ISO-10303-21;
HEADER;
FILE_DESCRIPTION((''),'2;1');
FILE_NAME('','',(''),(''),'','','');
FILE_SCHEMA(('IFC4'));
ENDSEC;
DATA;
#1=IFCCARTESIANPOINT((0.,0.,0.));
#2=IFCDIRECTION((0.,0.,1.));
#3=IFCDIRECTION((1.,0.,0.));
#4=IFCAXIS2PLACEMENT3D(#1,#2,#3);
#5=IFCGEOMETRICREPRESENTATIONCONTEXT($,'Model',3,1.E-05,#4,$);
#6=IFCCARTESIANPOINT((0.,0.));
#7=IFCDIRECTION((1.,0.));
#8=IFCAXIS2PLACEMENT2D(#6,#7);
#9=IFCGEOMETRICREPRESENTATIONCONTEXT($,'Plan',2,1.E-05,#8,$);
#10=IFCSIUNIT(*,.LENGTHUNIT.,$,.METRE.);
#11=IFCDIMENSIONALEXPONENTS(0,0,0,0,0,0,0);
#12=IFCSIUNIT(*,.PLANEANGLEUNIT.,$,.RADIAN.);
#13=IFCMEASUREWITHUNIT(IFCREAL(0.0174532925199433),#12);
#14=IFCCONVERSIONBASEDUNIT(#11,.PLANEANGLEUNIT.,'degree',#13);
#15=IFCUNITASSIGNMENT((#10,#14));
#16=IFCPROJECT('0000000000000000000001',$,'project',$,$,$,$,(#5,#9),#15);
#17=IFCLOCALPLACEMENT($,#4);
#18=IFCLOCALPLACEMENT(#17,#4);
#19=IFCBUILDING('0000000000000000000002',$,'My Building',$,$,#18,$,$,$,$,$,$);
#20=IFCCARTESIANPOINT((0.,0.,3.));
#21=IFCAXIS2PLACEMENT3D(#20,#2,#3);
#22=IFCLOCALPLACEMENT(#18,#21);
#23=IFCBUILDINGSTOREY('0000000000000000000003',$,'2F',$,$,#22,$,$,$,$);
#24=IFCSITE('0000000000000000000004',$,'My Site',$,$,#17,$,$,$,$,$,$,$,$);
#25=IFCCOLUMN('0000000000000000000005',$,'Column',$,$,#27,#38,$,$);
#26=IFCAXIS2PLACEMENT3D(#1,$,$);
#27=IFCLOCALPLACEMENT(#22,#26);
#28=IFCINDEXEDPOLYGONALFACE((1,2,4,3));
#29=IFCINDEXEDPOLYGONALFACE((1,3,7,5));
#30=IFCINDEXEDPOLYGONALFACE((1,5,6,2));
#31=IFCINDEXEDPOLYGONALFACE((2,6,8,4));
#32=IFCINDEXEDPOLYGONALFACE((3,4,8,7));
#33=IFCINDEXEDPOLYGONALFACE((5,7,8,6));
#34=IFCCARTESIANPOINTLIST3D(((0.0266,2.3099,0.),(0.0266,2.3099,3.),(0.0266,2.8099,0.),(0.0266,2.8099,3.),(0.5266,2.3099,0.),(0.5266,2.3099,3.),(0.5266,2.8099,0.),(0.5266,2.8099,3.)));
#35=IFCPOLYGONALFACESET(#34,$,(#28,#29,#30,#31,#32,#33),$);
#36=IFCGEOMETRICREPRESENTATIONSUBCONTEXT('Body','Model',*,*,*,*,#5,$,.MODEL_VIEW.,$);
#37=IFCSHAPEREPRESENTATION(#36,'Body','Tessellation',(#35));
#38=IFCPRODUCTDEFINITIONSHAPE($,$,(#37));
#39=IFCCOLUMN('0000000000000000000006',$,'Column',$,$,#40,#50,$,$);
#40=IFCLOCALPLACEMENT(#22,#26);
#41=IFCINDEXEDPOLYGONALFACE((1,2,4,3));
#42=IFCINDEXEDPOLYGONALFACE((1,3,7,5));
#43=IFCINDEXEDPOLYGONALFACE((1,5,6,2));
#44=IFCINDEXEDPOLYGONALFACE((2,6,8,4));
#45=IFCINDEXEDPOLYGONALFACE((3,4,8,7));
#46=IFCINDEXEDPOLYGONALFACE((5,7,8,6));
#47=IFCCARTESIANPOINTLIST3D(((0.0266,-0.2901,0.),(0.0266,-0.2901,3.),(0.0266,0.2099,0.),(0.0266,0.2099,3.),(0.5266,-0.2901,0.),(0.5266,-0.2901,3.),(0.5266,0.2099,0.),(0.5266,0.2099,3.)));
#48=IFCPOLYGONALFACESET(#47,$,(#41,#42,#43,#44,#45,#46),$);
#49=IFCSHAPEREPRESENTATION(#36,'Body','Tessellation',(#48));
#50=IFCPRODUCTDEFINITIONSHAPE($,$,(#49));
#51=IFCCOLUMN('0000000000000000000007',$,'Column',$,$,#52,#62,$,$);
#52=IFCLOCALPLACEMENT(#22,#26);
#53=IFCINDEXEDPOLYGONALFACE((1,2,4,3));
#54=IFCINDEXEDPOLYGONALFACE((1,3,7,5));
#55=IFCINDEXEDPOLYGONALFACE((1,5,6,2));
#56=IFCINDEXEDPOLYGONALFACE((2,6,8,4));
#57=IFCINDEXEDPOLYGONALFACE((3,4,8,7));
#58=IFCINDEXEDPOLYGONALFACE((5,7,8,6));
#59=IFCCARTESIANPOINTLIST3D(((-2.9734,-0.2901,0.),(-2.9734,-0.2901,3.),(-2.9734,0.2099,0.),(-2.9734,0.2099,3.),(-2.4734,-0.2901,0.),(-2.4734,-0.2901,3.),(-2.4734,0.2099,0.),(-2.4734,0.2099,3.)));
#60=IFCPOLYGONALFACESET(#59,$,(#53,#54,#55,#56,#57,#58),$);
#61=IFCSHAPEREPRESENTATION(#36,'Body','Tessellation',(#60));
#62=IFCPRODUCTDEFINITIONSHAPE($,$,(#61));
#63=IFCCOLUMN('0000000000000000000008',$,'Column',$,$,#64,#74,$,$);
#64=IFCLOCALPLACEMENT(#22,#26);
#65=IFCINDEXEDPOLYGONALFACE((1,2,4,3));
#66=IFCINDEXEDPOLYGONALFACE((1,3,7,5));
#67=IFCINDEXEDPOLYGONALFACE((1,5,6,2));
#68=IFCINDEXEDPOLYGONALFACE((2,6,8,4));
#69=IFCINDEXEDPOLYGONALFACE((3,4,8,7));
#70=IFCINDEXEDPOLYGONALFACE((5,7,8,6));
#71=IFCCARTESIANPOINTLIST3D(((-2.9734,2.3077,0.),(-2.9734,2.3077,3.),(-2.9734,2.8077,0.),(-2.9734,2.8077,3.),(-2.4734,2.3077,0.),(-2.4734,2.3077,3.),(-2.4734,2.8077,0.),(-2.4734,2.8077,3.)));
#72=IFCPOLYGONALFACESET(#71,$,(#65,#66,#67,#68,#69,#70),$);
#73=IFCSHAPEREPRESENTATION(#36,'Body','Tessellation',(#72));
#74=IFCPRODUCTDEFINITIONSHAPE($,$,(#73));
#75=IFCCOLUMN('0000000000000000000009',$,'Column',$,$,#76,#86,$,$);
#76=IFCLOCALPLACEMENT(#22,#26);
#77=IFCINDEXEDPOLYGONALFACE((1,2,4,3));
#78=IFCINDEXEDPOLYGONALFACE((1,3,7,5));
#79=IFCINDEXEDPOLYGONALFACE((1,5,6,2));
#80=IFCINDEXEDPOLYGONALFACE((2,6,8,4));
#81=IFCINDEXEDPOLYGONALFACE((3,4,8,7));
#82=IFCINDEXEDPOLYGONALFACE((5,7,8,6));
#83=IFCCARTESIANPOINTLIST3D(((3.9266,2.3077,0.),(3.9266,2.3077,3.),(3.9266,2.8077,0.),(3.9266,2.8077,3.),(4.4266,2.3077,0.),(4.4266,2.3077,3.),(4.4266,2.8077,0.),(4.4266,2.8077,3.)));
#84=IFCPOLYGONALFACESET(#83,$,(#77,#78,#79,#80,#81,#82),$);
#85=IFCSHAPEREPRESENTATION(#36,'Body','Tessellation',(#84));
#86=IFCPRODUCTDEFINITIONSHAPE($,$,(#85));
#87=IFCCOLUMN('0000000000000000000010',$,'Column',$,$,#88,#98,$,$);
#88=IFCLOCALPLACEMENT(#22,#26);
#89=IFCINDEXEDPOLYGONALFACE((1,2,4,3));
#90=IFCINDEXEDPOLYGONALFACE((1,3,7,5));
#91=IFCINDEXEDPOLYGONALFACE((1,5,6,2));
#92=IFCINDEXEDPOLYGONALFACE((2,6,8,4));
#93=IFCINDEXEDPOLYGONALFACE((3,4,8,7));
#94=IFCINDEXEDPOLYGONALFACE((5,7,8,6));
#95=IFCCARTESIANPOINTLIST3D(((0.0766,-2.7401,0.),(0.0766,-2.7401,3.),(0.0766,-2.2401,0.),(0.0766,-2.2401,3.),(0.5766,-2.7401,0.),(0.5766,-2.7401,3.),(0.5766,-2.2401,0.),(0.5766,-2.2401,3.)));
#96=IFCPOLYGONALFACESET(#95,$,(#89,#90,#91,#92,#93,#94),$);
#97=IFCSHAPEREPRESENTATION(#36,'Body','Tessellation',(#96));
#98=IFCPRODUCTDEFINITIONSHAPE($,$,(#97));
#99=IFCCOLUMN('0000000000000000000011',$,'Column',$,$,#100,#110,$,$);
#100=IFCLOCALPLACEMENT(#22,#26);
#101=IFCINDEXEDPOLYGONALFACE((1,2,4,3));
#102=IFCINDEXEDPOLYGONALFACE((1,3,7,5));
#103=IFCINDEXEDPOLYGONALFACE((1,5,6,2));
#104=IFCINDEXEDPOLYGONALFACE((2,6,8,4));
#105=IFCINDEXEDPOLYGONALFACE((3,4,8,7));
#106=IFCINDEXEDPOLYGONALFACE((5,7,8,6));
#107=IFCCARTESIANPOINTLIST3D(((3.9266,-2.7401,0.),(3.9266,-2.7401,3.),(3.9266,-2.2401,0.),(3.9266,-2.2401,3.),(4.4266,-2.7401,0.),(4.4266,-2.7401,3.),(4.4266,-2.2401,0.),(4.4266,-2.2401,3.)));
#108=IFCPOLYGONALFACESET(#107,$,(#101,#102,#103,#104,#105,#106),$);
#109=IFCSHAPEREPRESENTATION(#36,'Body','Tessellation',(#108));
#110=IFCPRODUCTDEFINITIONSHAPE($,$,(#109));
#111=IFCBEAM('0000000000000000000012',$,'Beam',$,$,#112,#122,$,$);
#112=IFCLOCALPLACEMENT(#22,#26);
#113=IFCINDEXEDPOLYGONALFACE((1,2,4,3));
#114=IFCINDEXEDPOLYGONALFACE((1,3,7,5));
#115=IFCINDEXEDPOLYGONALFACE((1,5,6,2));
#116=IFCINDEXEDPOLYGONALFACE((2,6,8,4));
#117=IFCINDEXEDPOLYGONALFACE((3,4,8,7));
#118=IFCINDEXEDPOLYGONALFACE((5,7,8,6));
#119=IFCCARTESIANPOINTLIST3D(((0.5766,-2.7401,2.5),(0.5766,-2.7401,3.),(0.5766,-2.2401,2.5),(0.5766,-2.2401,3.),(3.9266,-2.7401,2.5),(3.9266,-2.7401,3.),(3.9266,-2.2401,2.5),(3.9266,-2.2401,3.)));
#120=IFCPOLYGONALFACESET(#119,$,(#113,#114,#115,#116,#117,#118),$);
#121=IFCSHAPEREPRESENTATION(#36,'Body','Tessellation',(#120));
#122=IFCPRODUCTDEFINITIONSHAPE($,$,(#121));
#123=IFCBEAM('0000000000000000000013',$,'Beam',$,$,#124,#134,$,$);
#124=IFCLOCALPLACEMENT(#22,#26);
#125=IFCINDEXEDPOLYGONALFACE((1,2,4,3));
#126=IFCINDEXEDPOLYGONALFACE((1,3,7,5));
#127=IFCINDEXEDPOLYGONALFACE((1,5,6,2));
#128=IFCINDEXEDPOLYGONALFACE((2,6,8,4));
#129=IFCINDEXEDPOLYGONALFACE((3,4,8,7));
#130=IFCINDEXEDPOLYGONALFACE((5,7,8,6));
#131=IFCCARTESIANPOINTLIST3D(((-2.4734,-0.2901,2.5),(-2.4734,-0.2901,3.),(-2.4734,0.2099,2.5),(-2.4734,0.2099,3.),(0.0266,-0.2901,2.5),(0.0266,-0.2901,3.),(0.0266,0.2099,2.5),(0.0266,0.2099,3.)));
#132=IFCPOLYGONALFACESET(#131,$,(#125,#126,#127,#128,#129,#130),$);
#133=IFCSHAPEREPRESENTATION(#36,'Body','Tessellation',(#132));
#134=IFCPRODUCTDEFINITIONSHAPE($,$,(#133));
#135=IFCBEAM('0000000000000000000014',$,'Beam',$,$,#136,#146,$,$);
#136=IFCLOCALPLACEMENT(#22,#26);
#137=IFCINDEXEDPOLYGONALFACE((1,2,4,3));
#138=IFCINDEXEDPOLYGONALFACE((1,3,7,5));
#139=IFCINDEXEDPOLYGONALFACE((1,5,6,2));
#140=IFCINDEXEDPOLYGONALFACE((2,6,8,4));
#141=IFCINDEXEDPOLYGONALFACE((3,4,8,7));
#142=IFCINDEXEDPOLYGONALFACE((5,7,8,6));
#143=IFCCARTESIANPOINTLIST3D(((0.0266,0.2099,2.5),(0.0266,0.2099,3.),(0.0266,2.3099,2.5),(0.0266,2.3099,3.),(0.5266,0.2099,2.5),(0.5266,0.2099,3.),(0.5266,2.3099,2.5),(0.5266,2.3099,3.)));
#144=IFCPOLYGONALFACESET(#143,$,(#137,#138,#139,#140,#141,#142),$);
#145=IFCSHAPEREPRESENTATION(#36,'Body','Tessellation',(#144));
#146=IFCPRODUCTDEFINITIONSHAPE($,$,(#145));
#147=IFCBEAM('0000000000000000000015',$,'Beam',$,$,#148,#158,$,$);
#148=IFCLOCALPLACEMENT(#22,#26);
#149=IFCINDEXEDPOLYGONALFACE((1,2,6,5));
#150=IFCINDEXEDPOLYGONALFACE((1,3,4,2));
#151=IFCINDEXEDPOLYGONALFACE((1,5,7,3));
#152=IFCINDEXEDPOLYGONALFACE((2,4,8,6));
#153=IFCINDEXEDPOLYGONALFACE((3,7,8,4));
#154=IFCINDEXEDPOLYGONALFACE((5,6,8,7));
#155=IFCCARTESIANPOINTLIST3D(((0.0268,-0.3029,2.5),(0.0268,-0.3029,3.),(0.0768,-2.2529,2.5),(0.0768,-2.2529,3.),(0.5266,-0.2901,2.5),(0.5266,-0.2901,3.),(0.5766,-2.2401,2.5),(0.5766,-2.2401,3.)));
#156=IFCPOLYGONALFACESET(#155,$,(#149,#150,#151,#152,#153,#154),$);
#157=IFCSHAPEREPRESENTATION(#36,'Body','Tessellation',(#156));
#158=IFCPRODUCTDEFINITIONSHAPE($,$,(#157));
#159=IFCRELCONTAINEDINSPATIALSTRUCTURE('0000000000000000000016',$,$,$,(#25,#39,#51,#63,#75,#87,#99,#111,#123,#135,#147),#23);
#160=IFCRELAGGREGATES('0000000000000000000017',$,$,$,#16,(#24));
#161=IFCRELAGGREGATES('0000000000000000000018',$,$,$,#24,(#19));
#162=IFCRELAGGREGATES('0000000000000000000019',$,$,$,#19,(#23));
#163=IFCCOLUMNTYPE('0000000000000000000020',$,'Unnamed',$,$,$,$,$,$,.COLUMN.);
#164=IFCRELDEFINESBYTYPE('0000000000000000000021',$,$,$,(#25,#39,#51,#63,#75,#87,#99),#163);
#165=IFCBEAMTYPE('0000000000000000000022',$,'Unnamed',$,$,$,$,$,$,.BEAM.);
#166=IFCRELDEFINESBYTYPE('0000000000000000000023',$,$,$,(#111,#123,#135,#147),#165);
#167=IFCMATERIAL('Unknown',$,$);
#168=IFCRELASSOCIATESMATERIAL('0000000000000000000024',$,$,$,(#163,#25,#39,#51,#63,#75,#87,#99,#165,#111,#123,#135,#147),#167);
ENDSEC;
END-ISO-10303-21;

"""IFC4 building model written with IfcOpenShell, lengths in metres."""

from ifc_helpers import new_model, entity, si_unit, converted_unit, frame, origin_with_axes, origin_2d_with_axis, place, context, subcontext, project, spatial, rectangle, extrude, material, material_profile, profile_set, profile_usage, type_object, element, save


model = new_model("IFC4")

# Units and contexts
model_context = context("Model", 3, precision=1e-05, world=origin_with_axes())
plan_context = context("Plan", 2, precision=1e-05, world=origin_2d_with_axis())
body_context_1 = subcontext(model_context, "Body", "Model", "MODEL_VIEW")
ifc_project = project(units=[si_unit("LENGTHUNIT", "METRE"), converted_unit("PLANEANGLEUNIT", "degree", entity("IfcReal", 0.0174532925199433), si_unit("PLANEANGLEUNIT", "RADIAN"), dimensions=[0, 0, 0, 0, 0, 0, 0])], contexts=[model_context, plan_context])

# Site, building, storey
site_placement = place(None, origin_with_axes())
site = spatial("IfcSite", under=ifc_project, at=site_placement, Name="My Site")
building_placement = place(site_placement, origin_with_axes())
building = spatial("IfcBuilding", under=site, at=building_placement, Name="My Building")
storey_placement = place(building_placement, frame((0.0, 0.0, 3.0), z_axis=(0.0, 0.0, 1.0), x_axis=(1.0, 0.0, 0.0)))
storey = spatial("IfcBuildingStorey", under=building, at=storey_placement, Name="2F")

# Columns
ifc_material = material(Name="Unknown")
ifc_material_profile_1 = material_profile(ifc_material, rectangle(XDim=0.5, YDim=0.5))
ifc_profile_set_1 = profile_set([ifc_material_profile_1])
ifc_profile_usage_1 = profile_usage(ifc_profile_set_1, cardinal=5)
column_type = type_object("IfcColumnType", Name="Unnamed", PredefinedType="COLUMN", material=ifc_profile_set_1)
column_1_placement = place(storey_placement, frame((0.2766, 2.5599, 0.0), z_axis=(0.0, 0.0, 1.0), x_axis=(1.0, 0.0, 0.0)))
element("IfcColumn", 1, at=column_1_placement, inside=storey, type_object=column_type, material=ifc_profile_usage_1, Name="Column", context=body_context_1, shape_type="SweptSolid", body=[
    extrude(rectangle(XDim=0.5, YDim=0.5), origin_with_axes(), (0.0, 0.0, 1.0), 3.0),
])
ifc_profile_usage_2 = profile_usage(ifc_profile_set_1, cardinal=5)
column_2_placement = place(storey_placement, frame((0.2766, -0.0401, 0.0), z_axis=(0.0, 0.0, 1.0), x_axis=(1.0, 0.0, 0.0)))
element("IfcColumn", 2, at=column_2_placement, inside=storey, type_object=column_type, material=ifc_profile_usage_2, Name="Column", context=body_context_1, shape_type="SweptSolid", body=[
    extrude(rectangle(XDim=0.5, YDim=0.5), origin_with_axes(), (0.0, 0.0, 1.0), 3.0),
])
ifc_profile_usage_3 = profile_usage(ifc_profile_set_1, cardinal=5)
column_3_placement = place(storey_placement, frame((-2.7234, -0.0401, 0.0), z_axis=(0.0, 0.0, 1.0), x_axis=(1.0, 0.0, 0.0)))
element("IfcColumn", 3, at=column_3_placement, inside=storey, type_object=column_type, material=ifc_profile_usage_3, Name="Column", context=body_context_1, shape_type="SweptSolid", body=[
    extrude(rectangle(XDim=0.5, YDim=0.5), origin_with_axes(), (0.0, 0.0, 1.0), 3.0),
])
ifc_profile_usage_4 = profile_usage(ifc_profile_set_1, cardinal=5)
column_4_placement = place(storey_placement, frame((-2.7234, 2.5577, 0.0), z_axis=(0.0, 0.0, 1.0), x_axis=(1.0, 0.0, 0.0)))
element("IfcColumn", 4, at=column_4_placement, inside=storey, type_object=column_type, material=ifc_profile_usage_4, Name="Column", context=body_context_1, shape_type="SweptSolid", body=[
    extrude(rectangle(XDim=0.5, YDim=0.5), origin_with_axes(), (0.0, 0.0, 1.0), 3.0),
])
ifc_profile_usage_5 = profile_usage(ifc_profile_set_1, cardinal=5)
column_5_placement = place(storey_placement, frame((4.1766, 2.5577, 0.0), z_axis=(0.0, 0.0, 1.0), x_axis=(1.0, 0.0, 0.0)))
element("IfcColumn", 5, at=column_5_placement, inside=storey, type_object=column_type, material=ifc_profile_usage_5, Name="Column", context=body_context_1, shape_type="SweptSolid", body=[
    extrude(rectangle(XDim=0.5, YDim=0.5), origin_with_axes(), (0.0, 0.0, 1.0), 3.0),
])
ifc_profile_usage_6 = profile_usage(ifc_profile_set_1, cardinal=5)
column_6_placement = place(storey_placement, frame((0.3266, -2.4901, 0.0), z_axis=(0.0, 0.0, 1.0), x_axis=(1.0, 0.0, 0.0)))
element("IfcColumn", 6, at=column_6_placement, inside=storey, type_object=column_type, material=ifc_profile_usage_6, Name="Column", context=body_context_1, shape_type="SweptSolid", body=[
    extrude(rectangle(XDim=0.5, YDim=0.5), origin_with_axes(), (0.0, 0.0, 1.0), 3.0),
])
ifc_profile_usage_7 = profile_usage(ifc_profile_set_1, cardinal=5)
column_7_placement = place(storey_placement, frame((4.1766, -2.4901, 0.0), z_axis=(0.0, 0.0, 1.0), x_axis=(1.0, 0.0, 0.0)))
element("IfcColumn", 7, at=column_7_placement, inside=storey, type_object=column_type, material=ifc_profile_usage_7, Name="Column", context=body_context_1, shape_type="SweptSolid", body=[
    extrude(rectangle(XDim=0.5, YDim=0.5), origin_with_axes(), (0.0, 0.0, 1.0), 3.0),
])

# Beams
ifc_material_profile_2 = material_profile(ifc_material, rectangle(XDim=0.5, YDim=0.5))
ifc_profile_set_2 = profile_set([ifc_material_profile_2])
ifc_profile_usage_8 = profile_usage(ifc_profile_set_2, cardinal=7)
beam_type = type_object("IfcBeamType", Name="Unnamed", PredefinedType="BEAM", material=ifc_profile_set_2)
beam_1_placement = place(storey_placement, frame((0.5766, -2.2401, 3.0), z_axis=(1.0, -0.000001, 0.000001), x_axis=(0.000001, 1.0, 0.0)))
element("IfcBeam", 8, at=beam_1_placement, inside=storey, type_object=beam_type, material=ifc_profile_usage_8, Name="Beam", context=body_context_1, shape_type="SweptSolid", body=[
    extrude(rectangle(XDim=0.5, YDim=0.5), frame((-0.25, -0.25, 0.0), z_axis=(0.0, 0.0, 1.0), x_axis=(1.0, 0.0, 0.0)), (0.0, 0.0, 1.0), 3.35),
])
ifc_profile_usage_9 = profile_usage(ifc_profile_set_2, cardinal=7)
beam_2_placement = place(storey_placement, frame((-2.4734, 0.2099, 3.0), z_axis=(1.0, -0.000001, 0.000001), x_axis=(0.000001, 1.0, 0.0)))
element("IfcBeam", 9, at=beam_2_placement, inside=storey, type_object=beam_type, material=ifc_profile_usage_9, Name="Beam", context=body_context_1, shape_type="SweptSolid", body=[
    extrude(rectangle(XDim=0.5, YDim=0.5), frame((-0.25, -0.25, 0.0), z_axis=(0.0, 0.0, 1.0), x_axis=(1.0, 0.0, 0.0)), (0.0, 0.0, 1.0), 2.5),
])
ifc_profile_usage_10 = profile_usage(ifc_profile_set_2, cardinal=7)
beam_3_placement = place(storey_placement, frame((0.5266, 2.3099, 3.0), z_axis=(0.0, -1.0, 0.0), x_axis=(1.0, 0.0, 0.0)))
element("IfcBeam", 10, at=beam_3_placement, inside=storey, type_object=beam_type, material=ifc_profile_usage_10, Name="Beam", context=body_context_1, shape_type="SweptSolid", body=[
    extrude(rectangle(XDim=0.5, YDim=0.5), frame((-0.25, -0.25, 0.0), z_axis=(0.0, 0.0, 1.0), x_axis=(1.0, 0.0, 0.0)), (0.0, 0.0, 1.0), 2.1),
])
ifc_profile_usage_11 = profile_usage(ifc_profile_set_2, cardinal=7)
beam_4_placement = place(storey_placement, frame((0.5266, -0.2901, 3.0), z_axis=(0.025633, -0.999671, 0.0), x_axis=(0.999671, 0.025633, 0.0)))
element("IfcBeam", 11, at=beam_4_placement, inside=storey, type_object=beam_type, material=ifc_profile_usage_11, Name="Beam", context=body_context_1, shape_type="SweptSolid", body=[
    extrude(rectangle(XDim=0.5, YDim=0.5), frame((-0.25, -0.25, 0.0), z_axis=(0.0, 0.0, 1.0), x_axis=(1.0, 0.0, 0.0)), (0.0, 0.0, 1.0), 1.9506),
])

save(model, "model.ifc")
